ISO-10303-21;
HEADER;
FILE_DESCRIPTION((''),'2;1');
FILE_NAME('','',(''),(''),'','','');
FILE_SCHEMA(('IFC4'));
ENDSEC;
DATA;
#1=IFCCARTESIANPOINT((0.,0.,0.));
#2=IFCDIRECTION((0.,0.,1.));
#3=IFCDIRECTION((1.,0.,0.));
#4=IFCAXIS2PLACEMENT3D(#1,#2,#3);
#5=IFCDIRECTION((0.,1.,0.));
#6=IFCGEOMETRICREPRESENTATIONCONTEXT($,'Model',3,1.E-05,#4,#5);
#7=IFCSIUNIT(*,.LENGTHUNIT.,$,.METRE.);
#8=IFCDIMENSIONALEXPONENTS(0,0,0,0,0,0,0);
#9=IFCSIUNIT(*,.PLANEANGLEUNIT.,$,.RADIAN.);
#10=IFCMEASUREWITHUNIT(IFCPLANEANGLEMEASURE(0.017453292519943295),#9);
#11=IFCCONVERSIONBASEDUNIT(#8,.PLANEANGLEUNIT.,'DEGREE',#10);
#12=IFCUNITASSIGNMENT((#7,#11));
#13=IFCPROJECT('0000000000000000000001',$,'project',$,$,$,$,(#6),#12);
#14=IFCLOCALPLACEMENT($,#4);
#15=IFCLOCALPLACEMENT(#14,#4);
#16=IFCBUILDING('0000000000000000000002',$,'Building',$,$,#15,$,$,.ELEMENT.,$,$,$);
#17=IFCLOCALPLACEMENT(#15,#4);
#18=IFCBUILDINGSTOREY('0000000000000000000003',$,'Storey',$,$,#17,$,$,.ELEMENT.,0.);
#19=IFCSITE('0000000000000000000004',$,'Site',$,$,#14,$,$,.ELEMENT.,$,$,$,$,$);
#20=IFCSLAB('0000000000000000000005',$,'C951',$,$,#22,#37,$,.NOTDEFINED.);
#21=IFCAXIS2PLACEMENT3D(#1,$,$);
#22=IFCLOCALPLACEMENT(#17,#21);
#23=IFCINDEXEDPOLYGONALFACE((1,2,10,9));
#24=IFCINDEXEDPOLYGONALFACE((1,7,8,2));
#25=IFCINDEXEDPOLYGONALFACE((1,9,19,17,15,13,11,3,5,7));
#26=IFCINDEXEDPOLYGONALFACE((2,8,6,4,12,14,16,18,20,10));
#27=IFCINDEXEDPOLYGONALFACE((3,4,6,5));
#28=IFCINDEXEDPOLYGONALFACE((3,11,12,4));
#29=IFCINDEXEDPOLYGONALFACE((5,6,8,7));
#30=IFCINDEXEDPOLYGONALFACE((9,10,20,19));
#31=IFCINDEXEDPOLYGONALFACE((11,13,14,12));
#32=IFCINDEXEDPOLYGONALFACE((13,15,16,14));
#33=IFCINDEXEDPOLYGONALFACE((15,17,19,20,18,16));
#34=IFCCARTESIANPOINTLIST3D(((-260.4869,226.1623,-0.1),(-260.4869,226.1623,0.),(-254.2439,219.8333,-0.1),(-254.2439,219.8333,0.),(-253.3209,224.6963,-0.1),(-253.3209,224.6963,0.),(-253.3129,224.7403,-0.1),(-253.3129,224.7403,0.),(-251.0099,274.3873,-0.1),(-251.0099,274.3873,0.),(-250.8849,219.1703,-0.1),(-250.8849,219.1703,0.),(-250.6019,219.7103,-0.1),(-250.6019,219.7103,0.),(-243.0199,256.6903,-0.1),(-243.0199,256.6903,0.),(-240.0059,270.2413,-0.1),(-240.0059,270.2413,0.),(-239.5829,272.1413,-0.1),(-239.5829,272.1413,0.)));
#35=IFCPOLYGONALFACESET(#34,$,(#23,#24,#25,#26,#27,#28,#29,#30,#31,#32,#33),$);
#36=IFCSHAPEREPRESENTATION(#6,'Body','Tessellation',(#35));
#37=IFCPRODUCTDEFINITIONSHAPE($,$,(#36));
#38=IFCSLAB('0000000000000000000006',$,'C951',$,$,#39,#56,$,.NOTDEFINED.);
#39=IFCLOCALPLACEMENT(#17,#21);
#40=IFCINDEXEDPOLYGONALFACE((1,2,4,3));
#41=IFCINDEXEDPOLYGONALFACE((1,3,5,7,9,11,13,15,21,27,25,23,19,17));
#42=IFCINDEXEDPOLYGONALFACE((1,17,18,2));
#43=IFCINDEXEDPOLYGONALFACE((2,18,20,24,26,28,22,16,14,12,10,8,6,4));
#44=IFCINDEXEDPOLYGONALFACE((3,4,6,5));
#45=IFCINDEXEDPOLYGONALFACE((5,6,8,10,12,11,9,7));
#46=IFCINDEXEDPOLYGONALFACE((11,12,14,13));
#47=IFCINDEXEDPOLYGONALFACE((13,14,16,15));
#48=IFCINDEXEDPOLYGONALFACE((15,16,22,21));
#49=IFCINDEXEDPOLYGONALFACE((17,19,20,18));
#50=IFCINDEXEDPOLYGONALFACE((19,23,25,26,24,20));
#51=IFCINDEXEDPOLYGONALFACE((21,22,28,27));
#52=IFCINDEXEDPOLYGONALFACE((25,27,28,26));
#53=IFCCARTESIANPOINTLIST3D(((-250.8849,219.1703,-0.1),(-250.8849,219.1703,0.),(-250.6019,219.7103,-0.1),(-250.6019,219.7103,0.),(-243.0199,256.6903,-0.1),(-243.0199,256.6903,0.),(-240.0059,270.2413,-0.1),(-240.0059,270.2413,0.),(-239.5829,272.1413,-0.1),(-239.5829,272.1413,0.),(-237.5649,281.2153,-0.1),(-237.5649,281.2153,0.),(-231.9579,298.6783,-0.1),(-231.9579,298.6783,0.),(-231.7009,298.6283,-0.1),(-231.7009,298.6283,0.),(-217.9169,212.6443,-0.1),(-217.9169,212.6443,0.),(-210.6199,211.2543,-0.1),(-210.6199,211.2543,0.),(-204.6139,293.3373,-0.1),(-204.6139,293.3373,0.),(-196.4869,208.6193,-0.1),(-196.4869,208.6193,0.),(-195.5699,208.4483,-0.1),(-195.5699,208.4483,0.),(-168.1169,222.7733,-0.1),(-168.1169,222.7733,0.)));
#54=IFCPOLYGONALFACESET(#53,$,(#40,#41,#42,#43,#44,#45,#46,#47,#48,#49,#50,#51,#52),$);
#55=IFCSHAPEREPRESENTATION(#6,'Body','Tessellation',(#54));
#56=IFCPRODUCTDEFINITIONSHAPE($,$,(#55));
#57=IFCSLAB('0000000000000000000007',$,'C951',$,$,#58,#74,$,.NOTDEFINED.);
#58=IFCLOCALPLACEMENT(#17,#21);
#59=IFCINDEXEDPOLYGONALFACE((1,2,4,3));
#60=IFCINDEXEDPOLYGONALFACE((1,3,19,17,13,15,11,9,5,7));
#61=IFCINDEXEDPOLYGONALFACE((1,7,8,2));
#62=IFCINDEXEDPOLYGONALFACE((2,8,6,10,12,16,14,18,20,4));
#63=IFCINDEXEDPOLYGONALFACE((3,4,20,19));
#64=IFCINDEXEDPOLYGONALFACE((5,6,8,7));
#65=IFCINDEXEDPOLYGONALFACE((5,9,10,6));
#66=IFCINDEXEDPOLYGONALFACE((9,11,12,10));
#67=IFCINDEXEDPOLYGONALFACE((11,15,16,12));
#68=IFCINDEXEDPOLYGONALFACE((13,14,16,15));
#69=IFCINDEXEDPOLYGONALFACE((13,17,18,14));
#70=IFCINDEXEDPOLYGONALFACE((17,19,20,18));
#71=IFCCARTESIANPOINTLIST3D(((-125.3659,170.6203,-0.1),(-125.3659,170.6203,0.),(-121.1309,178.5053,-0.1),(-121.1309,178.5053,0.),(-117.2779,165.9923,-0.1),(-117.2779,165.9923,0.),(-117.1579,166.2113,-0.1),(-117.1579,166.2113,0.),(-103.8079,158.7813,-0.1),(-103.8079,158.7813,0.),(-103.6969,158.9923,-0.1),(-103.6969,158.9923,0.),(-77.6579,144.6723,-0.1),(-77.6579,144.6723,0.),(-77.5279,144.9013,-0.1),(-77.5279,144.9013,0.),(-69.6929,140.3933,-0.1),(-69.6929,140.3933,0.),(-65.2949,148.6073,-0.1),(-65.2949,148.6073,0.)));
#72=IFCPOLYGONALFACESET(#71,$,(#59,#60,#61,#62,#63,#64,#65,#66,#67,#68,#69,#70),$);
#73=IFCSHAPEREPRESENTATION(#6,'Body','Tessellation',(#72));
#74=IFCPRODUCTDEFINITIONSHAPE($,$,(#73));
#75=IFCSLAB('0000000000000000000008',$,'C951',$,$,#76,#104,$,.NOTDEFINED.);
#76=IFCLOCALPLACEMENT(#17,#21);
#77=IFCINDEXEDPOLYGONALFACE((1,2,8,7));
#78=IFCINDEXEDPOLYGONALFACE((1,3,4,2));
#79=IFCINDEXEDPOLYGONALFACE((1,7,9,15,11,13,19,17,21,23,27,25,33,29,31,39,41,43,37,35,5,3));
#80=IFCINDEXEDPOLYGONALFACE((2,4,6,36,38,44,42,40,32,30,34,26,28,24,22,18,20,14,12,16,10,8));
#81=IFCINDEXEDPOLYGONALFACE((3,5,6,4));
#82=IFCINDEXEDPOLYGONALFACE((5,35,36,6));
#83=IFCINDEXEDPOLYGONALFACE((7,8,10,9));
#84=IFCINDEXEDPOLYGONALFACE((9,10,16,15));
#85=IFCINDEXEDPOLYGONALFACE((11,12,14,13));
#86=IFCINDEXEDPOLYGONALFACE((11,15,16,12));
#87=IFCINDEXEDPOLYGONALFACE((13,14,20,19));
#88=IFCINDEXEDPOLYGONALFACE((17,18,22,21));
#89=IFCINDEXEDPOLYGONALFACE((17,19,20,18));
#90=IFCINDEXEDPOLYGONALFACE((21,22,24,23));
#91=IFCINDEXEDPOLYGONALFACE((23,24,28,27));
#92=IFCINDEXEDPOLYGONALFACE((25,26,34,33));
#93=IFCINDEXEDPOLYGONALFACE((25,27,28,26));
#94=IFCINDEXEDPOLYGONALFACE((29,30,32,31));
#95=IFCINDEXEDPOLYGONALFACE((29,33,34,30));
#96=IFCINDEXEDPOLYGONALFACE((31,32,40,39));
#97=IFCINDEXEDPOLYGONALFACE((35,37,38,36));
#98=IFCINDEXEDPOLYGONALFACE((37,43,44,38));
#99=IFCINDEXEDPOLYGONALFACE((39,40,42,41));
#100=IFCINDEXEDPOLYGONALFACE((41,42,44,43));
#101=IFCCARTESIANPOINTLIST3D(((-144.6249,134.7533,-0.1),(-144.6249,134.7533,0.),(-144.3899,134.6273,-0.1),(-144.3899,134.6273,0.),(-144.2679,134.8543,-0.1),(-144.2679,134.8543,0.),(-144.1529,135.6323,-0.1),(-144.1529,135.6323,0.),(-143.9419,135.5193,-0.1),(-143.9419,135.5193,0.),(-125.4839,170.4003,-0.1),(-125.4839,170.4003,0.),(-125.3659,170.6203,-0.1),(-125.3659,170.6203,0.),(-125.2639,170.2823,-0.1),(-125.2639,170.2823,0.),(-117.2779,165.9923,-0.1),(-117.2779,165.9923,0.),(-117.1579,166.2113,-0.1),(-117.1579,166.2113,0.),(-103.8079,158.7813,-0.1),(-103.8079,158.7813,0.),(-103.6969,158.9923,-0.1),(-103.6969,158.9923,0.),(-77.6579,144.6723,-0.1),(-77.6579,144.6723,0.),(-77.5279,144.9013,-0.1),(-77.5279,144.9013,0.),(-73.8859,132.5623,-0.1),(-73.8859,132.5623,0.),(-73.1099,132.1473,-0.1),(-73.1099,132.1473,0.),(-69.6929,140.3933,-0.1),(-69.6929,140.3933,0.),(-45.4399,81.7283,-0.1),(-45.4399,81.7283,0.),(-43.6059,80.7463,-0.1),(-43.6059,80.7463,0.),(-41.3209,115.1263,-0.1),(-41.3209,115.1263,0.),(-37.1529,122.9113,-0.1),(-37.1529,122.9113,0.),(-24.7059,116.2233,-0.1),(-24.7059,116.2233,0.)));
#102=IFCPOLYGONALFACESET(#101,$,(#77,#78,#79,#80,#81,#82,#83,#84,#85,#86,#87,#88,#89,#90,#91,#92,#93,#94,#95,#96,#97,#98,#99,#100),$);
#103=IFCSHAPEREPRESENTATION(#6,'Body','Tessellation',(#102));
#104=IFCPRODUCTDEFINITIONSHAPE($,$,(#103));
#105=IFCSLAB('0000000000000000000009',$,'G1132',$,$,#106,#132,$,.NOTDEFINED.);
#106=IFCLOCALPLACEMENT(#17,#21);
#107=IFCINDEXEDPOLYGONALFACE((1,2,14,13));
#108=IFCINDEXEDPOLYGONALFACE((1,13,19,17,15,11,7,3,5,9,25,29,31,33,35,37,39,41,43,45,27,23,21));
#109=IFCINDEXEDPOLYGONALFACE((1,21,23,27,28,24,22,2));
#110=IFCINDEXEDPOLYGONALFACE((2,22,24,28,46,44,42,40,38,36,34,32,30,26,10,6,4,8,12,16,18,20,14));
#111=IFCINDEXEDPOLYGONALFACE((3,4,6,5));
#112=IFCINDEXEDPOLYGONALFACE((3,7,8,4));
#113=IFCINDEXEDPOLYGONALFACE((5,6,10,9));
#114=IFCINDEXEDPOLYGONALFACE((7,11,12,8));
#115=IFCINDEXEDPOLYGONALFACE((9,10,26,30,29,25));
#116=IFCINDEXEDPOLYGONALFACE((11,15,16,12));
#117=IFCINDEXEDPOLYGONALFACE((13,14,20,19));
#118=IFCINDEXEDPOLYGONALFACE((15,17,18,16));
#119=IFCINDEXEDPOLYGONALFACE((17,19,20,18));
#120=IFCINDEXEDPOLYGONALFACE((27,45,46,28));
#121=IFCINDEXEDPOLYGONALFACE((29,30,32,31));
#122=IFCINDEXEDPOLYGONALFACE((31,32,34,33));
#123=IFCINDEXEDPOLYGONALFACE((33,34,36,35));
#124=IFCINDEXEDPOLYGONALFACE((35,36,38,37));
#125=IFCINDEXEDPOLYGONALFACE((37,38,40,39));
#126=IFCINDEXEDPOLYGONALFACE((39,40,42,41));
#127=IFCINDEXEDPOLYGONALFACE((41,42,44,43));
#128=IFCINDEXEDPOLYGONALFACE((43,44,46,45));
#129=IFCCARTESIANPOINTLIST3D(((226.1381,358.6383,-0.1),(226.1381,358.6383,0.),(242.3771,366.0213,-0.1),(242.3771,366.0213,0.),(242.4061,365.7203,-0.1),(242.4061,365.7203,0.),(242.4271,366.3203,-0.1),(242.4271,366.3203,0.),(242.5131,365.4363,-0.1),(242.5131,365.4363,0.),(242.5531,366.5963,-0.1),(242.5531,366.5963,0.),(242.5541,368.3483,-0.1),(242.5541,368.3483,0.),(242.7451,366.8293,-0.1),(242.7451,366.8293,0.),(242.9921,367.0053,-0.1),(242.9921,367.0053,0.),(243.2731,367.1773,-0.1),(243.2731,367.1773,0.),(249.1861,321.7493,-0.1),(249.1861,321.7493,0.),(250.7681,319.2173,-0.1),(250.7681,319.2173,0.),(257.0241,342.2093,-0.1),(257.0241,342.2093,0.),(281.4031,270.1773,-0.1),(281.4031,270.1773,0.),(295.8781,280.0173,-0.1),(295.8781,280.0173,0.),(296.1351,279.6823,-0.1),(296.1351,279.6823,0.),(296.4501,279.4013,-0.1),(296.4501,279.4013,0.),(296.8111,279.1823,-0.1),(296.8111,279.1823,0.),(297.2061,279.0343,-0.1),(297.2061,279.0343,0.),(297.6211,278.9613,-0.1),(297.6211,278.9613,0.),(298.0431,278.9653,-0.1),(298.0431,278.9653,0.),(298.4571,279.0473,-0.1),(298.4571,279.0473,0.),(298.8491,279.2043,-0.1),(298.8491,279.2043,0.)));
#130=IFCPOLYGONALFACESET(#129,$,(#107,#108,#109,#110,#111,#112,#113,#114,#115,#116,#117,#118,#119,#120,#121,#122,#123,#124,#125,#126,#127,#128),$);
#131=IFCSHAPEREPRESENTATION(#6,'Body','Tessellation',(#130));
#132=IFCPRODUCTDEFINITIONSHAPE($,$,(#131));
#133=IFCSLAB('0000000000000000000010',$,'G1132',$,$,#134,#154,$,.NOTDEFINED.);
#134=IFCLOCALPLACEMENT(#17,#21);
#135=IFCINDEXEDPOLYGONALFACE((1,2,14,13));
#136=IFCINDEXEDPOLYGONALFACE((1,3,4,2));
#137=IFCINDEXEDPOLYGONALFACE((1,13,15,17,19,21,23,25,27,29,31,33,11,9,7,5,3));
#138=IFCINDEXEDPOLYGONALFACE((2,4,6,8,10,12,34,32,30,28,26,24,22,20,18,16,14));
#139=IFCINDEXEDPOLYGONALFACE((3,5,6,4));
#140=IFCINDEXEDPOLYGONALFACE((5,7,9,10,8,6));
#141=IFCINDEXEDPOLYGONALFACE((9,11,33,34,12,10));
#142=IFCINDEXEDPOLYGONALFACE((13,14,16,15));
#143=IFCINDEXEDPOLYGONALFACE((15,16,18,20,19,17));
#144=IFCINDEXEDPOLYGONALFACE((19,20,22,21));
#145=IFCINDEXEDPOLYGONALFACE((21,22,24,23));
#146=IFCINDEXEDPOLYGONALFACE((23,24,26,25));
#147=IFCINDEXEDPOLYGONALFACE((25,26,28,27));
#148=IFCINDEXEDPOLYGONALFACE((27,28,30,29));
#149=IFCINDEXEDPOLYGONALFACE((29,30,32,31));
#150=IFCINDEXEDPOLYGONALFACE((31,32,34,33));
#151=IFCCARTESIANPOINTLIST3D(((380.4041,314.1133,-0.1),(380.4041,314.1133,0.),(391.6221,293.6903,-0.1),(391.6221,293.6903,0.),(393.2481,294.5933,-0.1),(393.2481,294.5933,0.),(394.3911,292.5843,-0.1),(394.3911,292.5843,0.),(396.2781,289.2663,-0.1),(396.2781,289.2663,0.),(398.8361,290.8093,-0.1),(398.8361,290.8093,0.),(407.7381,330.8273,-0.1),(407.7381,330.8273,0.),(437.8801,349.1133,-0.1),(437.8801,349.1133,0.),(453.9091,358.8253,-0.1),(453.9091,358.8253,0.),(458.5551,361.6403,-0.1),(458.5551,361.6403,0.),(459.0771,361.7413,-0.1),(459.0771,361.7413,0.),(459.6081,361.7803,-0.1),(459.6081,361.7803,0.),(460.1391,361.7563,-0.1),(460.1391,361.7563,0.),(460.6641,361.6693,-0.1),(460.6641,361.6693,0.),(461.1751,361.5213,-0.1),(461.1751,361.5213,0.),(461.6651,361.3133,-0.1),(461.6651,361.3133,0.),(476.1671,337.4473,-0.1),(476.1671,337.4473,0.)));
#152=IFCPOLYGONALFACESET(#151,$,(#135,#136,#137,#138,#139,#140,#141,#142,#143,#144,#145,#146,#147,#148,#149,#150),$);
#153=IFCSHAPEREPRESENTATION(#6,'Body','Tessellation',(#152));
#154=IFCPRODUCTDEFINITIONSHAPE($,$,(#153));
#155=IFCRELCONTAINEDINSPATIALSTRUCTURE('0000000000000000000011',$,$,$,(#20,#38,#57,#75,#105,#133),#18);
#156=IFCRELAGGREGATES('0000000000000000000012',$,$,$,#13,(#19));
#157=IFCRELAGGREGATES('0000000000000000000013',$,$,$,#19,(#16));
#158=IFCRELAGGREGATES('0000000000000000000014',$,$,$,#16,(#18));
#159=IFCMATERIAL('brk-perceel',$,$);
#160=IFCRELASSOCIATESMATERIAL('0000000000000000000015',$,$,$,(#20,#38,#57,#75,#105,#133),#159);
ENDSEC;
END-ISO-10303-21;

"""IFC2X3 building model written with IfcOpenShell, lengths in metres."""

from ifc_helpers import new_model, entity, si_unit, converted_unit, direction, frame, origin_with_axes, place, context, project, spatial, polyline, outline, extrude, material, element, save


model = new_model("IFC2X3")

# Units and contexts
model_context = context("Model", 3, precision=1e-05, world=origin_with_axes(), true_north=direction((0.0, 1.0, 0.0)))
ifc_project = project(units=[si_unit("LENGTHUNIT", "METRE"), converted_unit("PLANEANGLEUNIT", "DEGREE", entity("IfcPlaneAngleMeasure", 0.017453292519943295), si_unit("PLANEANGLEUNIT", "RADIAN"), dimensions=[0, 0, 0, 0, 0, 0, 0])], contexts=[model_context])

# Site, building, storey
site_placement = place(None, origin_with_axes())
site = spatial("IfcSite", under=ifc_project, at=site_placement, Name="Site", CompositionType="ELEMENT")
building_placement = place(site_placement, origin_with_axes())
building = spatial("IfcBuilding", under=site, at=building_placement, Name="Building", CompositionType="ELEMENT")
storey_placement = place(building_placement, origin_with_axes())
storey = spatial("IfcBuildingStorey", under=building, at=storey_placement, Name="Storey", CompositionType="ELEMENT", Elevation=0.0)

# Slabs
ifc_material = material(Name="brk-perceel")
slab_1_placement = place(storey_placement, frame((0.0, 0.0, -0.1), z_axis=(0.0, 0.0, 1.0), x_axis=(1.0, 0.0, 0.0)))
element("IfcSlab", 1, at=slab_1_placement, inside=storey, material=ifc_material, Name="C951", PredefinedType="NOTDEFINED", context=model_context, shape_type="SweptSolid", body=[
    extrude(outline(polyline([(-243.0199, 256.6903), (-250.6019, 219.7103), (-250.8849, 219.1703), (-254.2439, 219.8333), (-253.3209, 224.6963), (-253.3129, 224.7403), (-260.4869, 226.1623), (-251.0099, 274.3873), (-239.5829, 272.1413), (-240.0059, 270.2413), (-243.0199, 256.6903)])), origin_with_axes(), (0.0, 0.0, 1.0), 0.1),
])
slab_2_placement = place(storey_placement, frame((0.0, 0.0, -0.1), z_axis=(0.0, 0.0, 1.0), x_axis=(1.0, 0.0, 0.0)))
element("IfcSlab", 2, at=slab_2_placement, inside=storey, material=ifc_material, Name="C951", PredefinedType="NOTDEFINED", context=model_context, shape_type="SweptSolid", body=[
    extrude(outline(polyline([(-195.5699, 208.4483), (-196.4869, 208.6193), (-210.6199, 211.2543), (-217.9169, 212.6443), (-250.8849, 219.1703), (-250.6019, 219.7103), (-243.0199, 256.6903), (-240.0059, 270.2413), (-239.5829, 272.1413), (-237.5649, 281.2153), (-231.9579, 298.6783), (-231.7009, 298.6283), (-204.6139, 293.3373), (-168.1169, 222.7733), (-195.5699, 208.4483)])), origin_with_axes(), (0.0, 0.0, 1.0), 0.1),
])
slab_3_placement = place(storey_placement, frame((0.0, 0.0, -0.1), z_axis=(0.0, 0.0, 1.0), x_axis=(1.0, 0.0, 0.0)))
element("IfcSlab", 3, at=slab_3_placement, inside=storey, material=ifc_material, Name="C951", PredefinedType="NOTDEFINED", context=model_context, shape_type="SweptSolid", body=[
    extrude(outline(polyline([(-77.6579, 144.6723), (-77.5279, 144.9013), (-103.6969, 158.9923), (-103.8079, 158.7813), (-117.2779, 165.9923), (-117.1579, 166.2113), (-125.3659, 170.6203), (-121.1309, 178.5053), (-65.2949, 148.6073), (-69.6929, 140.3933), (-77.6579, 144.6723)])), origin_with_axes(), (0.0, 0.0, 1.0), 0.1),
])
slab_4_placement = place(storey_placement, frame((0.0, 0.0, -0.1), z_axis=(0.0, 0.0, 1.0), x_axis=(1.0, 0.0, 0.0)))
element("IfcSlab", 4, at=slab_4_placement, inside=storey, material=ifc_material, Name="C951", PredefinedType="NOTDEFINED", context=model_context, shape_type="SweptSolid", body=[
    extrude(outline(polyline([(-144.6249, 134.7533), (-144.1529, 135.6323), (-143.9419, 135.5193), (-125.2639, 170.2823), (-125.4839, 170.4003), (-125.3659, 170.6203), (-117.1579, 166.2113), (-117.2779, 165.9923), (-103.8079, 158.7813), (-103.6969, 158.9923), (-77.5279, 144.9013), (-77.6579, 144.6723), (-69.6929, 140.3933), (-73.8859, 132.5623), (-73.1099, 132.1473), (-41.3209, 115.1263), (-37.1529, 122.9113), (-24.7059, 116.2233), (-43.6059, 80.7463), (-45.4399, 81.7283), (-144.2679, 134.8543), (-144.3899, 134.6273), (-144.6249, 134.7533)])), origin_with_axes(), (0.0, 0.0, 1.0), 0.1),
])
slab_5_placement = place(storey_placement, frame((0.0, 0.0, -0.1), z_axis=(0.0, 0.0, 1.0), x_axis=(1.0, 0.0, 0.0)))
element("IfcSlab", 5, at=slab_5_placement, inside=storey, material=ifc_material, Name="G1132", PredefinedType="NOTDEFINED", context=model_context, shape_type="SweptSolid", body=[
    extrude(outline(polyline([(295.8781, 280.0173), (296.1351, 279.6823), (296.4501, 279.4013), (296.8111, 279.1823), (297.2061, 279.0343), (297.6211, 278.9613), (298.0431, 278.9653), (298.4571, 279.0473), (298.8491, 279.2043), (281.4031, 270.1773), (250.7681, 319.2173), (249.1861, 321.7493), (226.1381, 358.6383), (242.5541, 368.3483), (243.2731, 367.1773), (242.9921, 367.0053), (242.7451, 366.8293), (242.5531, 366.5963), (242.4271, 366.3203), (242.3771, 366.0213), (242.4061, 365.7203), (242.5131, 365.4363), (257.0241, 342.2093), (295.8781, 280.0173)])), origin_with_axes(), (0.0, 0.0, 1.0), 0.1),
])
slab_6_placement = place(storey_placement, frame((0.0, 0.0, -0.1), z_axis=(0.0, 0.0, 1.0), x_axis=(1.0, 0.0, 0.0)))
element("IfcSlab", 6, at=slab_6_placement, inside=storey, material=ifc_material, Name="G1132", PredefinedType="NOTDEFINED", context=model_context, shape_type="SweptSolid", body=[
    extrude(outline(polyline([(459.0771, 361.7413), (459.6081, 361.7803), (460.1391, 361.7563), (460.6641, 361.6693), (461.1751, 361.5213), (461.6651, 361.3133), (476.1671, 337.4473), (398.8361, 290.8093), (396.2781, 289.2663), (394.3911, 292.5843), (393.2481, 294.5933), (391.6221, 293.6903), (380.4041, 314.1133), (407.7381, 330.8273), (437.8801, 349.1133), (453.9091, 358.8253), (458.5551, 361.6403), (459.0771, 361.7413)])), origin_with_axes(), (0.0, 0.0, 1.0), 0.1),
])

save(model, "model.ifc")
